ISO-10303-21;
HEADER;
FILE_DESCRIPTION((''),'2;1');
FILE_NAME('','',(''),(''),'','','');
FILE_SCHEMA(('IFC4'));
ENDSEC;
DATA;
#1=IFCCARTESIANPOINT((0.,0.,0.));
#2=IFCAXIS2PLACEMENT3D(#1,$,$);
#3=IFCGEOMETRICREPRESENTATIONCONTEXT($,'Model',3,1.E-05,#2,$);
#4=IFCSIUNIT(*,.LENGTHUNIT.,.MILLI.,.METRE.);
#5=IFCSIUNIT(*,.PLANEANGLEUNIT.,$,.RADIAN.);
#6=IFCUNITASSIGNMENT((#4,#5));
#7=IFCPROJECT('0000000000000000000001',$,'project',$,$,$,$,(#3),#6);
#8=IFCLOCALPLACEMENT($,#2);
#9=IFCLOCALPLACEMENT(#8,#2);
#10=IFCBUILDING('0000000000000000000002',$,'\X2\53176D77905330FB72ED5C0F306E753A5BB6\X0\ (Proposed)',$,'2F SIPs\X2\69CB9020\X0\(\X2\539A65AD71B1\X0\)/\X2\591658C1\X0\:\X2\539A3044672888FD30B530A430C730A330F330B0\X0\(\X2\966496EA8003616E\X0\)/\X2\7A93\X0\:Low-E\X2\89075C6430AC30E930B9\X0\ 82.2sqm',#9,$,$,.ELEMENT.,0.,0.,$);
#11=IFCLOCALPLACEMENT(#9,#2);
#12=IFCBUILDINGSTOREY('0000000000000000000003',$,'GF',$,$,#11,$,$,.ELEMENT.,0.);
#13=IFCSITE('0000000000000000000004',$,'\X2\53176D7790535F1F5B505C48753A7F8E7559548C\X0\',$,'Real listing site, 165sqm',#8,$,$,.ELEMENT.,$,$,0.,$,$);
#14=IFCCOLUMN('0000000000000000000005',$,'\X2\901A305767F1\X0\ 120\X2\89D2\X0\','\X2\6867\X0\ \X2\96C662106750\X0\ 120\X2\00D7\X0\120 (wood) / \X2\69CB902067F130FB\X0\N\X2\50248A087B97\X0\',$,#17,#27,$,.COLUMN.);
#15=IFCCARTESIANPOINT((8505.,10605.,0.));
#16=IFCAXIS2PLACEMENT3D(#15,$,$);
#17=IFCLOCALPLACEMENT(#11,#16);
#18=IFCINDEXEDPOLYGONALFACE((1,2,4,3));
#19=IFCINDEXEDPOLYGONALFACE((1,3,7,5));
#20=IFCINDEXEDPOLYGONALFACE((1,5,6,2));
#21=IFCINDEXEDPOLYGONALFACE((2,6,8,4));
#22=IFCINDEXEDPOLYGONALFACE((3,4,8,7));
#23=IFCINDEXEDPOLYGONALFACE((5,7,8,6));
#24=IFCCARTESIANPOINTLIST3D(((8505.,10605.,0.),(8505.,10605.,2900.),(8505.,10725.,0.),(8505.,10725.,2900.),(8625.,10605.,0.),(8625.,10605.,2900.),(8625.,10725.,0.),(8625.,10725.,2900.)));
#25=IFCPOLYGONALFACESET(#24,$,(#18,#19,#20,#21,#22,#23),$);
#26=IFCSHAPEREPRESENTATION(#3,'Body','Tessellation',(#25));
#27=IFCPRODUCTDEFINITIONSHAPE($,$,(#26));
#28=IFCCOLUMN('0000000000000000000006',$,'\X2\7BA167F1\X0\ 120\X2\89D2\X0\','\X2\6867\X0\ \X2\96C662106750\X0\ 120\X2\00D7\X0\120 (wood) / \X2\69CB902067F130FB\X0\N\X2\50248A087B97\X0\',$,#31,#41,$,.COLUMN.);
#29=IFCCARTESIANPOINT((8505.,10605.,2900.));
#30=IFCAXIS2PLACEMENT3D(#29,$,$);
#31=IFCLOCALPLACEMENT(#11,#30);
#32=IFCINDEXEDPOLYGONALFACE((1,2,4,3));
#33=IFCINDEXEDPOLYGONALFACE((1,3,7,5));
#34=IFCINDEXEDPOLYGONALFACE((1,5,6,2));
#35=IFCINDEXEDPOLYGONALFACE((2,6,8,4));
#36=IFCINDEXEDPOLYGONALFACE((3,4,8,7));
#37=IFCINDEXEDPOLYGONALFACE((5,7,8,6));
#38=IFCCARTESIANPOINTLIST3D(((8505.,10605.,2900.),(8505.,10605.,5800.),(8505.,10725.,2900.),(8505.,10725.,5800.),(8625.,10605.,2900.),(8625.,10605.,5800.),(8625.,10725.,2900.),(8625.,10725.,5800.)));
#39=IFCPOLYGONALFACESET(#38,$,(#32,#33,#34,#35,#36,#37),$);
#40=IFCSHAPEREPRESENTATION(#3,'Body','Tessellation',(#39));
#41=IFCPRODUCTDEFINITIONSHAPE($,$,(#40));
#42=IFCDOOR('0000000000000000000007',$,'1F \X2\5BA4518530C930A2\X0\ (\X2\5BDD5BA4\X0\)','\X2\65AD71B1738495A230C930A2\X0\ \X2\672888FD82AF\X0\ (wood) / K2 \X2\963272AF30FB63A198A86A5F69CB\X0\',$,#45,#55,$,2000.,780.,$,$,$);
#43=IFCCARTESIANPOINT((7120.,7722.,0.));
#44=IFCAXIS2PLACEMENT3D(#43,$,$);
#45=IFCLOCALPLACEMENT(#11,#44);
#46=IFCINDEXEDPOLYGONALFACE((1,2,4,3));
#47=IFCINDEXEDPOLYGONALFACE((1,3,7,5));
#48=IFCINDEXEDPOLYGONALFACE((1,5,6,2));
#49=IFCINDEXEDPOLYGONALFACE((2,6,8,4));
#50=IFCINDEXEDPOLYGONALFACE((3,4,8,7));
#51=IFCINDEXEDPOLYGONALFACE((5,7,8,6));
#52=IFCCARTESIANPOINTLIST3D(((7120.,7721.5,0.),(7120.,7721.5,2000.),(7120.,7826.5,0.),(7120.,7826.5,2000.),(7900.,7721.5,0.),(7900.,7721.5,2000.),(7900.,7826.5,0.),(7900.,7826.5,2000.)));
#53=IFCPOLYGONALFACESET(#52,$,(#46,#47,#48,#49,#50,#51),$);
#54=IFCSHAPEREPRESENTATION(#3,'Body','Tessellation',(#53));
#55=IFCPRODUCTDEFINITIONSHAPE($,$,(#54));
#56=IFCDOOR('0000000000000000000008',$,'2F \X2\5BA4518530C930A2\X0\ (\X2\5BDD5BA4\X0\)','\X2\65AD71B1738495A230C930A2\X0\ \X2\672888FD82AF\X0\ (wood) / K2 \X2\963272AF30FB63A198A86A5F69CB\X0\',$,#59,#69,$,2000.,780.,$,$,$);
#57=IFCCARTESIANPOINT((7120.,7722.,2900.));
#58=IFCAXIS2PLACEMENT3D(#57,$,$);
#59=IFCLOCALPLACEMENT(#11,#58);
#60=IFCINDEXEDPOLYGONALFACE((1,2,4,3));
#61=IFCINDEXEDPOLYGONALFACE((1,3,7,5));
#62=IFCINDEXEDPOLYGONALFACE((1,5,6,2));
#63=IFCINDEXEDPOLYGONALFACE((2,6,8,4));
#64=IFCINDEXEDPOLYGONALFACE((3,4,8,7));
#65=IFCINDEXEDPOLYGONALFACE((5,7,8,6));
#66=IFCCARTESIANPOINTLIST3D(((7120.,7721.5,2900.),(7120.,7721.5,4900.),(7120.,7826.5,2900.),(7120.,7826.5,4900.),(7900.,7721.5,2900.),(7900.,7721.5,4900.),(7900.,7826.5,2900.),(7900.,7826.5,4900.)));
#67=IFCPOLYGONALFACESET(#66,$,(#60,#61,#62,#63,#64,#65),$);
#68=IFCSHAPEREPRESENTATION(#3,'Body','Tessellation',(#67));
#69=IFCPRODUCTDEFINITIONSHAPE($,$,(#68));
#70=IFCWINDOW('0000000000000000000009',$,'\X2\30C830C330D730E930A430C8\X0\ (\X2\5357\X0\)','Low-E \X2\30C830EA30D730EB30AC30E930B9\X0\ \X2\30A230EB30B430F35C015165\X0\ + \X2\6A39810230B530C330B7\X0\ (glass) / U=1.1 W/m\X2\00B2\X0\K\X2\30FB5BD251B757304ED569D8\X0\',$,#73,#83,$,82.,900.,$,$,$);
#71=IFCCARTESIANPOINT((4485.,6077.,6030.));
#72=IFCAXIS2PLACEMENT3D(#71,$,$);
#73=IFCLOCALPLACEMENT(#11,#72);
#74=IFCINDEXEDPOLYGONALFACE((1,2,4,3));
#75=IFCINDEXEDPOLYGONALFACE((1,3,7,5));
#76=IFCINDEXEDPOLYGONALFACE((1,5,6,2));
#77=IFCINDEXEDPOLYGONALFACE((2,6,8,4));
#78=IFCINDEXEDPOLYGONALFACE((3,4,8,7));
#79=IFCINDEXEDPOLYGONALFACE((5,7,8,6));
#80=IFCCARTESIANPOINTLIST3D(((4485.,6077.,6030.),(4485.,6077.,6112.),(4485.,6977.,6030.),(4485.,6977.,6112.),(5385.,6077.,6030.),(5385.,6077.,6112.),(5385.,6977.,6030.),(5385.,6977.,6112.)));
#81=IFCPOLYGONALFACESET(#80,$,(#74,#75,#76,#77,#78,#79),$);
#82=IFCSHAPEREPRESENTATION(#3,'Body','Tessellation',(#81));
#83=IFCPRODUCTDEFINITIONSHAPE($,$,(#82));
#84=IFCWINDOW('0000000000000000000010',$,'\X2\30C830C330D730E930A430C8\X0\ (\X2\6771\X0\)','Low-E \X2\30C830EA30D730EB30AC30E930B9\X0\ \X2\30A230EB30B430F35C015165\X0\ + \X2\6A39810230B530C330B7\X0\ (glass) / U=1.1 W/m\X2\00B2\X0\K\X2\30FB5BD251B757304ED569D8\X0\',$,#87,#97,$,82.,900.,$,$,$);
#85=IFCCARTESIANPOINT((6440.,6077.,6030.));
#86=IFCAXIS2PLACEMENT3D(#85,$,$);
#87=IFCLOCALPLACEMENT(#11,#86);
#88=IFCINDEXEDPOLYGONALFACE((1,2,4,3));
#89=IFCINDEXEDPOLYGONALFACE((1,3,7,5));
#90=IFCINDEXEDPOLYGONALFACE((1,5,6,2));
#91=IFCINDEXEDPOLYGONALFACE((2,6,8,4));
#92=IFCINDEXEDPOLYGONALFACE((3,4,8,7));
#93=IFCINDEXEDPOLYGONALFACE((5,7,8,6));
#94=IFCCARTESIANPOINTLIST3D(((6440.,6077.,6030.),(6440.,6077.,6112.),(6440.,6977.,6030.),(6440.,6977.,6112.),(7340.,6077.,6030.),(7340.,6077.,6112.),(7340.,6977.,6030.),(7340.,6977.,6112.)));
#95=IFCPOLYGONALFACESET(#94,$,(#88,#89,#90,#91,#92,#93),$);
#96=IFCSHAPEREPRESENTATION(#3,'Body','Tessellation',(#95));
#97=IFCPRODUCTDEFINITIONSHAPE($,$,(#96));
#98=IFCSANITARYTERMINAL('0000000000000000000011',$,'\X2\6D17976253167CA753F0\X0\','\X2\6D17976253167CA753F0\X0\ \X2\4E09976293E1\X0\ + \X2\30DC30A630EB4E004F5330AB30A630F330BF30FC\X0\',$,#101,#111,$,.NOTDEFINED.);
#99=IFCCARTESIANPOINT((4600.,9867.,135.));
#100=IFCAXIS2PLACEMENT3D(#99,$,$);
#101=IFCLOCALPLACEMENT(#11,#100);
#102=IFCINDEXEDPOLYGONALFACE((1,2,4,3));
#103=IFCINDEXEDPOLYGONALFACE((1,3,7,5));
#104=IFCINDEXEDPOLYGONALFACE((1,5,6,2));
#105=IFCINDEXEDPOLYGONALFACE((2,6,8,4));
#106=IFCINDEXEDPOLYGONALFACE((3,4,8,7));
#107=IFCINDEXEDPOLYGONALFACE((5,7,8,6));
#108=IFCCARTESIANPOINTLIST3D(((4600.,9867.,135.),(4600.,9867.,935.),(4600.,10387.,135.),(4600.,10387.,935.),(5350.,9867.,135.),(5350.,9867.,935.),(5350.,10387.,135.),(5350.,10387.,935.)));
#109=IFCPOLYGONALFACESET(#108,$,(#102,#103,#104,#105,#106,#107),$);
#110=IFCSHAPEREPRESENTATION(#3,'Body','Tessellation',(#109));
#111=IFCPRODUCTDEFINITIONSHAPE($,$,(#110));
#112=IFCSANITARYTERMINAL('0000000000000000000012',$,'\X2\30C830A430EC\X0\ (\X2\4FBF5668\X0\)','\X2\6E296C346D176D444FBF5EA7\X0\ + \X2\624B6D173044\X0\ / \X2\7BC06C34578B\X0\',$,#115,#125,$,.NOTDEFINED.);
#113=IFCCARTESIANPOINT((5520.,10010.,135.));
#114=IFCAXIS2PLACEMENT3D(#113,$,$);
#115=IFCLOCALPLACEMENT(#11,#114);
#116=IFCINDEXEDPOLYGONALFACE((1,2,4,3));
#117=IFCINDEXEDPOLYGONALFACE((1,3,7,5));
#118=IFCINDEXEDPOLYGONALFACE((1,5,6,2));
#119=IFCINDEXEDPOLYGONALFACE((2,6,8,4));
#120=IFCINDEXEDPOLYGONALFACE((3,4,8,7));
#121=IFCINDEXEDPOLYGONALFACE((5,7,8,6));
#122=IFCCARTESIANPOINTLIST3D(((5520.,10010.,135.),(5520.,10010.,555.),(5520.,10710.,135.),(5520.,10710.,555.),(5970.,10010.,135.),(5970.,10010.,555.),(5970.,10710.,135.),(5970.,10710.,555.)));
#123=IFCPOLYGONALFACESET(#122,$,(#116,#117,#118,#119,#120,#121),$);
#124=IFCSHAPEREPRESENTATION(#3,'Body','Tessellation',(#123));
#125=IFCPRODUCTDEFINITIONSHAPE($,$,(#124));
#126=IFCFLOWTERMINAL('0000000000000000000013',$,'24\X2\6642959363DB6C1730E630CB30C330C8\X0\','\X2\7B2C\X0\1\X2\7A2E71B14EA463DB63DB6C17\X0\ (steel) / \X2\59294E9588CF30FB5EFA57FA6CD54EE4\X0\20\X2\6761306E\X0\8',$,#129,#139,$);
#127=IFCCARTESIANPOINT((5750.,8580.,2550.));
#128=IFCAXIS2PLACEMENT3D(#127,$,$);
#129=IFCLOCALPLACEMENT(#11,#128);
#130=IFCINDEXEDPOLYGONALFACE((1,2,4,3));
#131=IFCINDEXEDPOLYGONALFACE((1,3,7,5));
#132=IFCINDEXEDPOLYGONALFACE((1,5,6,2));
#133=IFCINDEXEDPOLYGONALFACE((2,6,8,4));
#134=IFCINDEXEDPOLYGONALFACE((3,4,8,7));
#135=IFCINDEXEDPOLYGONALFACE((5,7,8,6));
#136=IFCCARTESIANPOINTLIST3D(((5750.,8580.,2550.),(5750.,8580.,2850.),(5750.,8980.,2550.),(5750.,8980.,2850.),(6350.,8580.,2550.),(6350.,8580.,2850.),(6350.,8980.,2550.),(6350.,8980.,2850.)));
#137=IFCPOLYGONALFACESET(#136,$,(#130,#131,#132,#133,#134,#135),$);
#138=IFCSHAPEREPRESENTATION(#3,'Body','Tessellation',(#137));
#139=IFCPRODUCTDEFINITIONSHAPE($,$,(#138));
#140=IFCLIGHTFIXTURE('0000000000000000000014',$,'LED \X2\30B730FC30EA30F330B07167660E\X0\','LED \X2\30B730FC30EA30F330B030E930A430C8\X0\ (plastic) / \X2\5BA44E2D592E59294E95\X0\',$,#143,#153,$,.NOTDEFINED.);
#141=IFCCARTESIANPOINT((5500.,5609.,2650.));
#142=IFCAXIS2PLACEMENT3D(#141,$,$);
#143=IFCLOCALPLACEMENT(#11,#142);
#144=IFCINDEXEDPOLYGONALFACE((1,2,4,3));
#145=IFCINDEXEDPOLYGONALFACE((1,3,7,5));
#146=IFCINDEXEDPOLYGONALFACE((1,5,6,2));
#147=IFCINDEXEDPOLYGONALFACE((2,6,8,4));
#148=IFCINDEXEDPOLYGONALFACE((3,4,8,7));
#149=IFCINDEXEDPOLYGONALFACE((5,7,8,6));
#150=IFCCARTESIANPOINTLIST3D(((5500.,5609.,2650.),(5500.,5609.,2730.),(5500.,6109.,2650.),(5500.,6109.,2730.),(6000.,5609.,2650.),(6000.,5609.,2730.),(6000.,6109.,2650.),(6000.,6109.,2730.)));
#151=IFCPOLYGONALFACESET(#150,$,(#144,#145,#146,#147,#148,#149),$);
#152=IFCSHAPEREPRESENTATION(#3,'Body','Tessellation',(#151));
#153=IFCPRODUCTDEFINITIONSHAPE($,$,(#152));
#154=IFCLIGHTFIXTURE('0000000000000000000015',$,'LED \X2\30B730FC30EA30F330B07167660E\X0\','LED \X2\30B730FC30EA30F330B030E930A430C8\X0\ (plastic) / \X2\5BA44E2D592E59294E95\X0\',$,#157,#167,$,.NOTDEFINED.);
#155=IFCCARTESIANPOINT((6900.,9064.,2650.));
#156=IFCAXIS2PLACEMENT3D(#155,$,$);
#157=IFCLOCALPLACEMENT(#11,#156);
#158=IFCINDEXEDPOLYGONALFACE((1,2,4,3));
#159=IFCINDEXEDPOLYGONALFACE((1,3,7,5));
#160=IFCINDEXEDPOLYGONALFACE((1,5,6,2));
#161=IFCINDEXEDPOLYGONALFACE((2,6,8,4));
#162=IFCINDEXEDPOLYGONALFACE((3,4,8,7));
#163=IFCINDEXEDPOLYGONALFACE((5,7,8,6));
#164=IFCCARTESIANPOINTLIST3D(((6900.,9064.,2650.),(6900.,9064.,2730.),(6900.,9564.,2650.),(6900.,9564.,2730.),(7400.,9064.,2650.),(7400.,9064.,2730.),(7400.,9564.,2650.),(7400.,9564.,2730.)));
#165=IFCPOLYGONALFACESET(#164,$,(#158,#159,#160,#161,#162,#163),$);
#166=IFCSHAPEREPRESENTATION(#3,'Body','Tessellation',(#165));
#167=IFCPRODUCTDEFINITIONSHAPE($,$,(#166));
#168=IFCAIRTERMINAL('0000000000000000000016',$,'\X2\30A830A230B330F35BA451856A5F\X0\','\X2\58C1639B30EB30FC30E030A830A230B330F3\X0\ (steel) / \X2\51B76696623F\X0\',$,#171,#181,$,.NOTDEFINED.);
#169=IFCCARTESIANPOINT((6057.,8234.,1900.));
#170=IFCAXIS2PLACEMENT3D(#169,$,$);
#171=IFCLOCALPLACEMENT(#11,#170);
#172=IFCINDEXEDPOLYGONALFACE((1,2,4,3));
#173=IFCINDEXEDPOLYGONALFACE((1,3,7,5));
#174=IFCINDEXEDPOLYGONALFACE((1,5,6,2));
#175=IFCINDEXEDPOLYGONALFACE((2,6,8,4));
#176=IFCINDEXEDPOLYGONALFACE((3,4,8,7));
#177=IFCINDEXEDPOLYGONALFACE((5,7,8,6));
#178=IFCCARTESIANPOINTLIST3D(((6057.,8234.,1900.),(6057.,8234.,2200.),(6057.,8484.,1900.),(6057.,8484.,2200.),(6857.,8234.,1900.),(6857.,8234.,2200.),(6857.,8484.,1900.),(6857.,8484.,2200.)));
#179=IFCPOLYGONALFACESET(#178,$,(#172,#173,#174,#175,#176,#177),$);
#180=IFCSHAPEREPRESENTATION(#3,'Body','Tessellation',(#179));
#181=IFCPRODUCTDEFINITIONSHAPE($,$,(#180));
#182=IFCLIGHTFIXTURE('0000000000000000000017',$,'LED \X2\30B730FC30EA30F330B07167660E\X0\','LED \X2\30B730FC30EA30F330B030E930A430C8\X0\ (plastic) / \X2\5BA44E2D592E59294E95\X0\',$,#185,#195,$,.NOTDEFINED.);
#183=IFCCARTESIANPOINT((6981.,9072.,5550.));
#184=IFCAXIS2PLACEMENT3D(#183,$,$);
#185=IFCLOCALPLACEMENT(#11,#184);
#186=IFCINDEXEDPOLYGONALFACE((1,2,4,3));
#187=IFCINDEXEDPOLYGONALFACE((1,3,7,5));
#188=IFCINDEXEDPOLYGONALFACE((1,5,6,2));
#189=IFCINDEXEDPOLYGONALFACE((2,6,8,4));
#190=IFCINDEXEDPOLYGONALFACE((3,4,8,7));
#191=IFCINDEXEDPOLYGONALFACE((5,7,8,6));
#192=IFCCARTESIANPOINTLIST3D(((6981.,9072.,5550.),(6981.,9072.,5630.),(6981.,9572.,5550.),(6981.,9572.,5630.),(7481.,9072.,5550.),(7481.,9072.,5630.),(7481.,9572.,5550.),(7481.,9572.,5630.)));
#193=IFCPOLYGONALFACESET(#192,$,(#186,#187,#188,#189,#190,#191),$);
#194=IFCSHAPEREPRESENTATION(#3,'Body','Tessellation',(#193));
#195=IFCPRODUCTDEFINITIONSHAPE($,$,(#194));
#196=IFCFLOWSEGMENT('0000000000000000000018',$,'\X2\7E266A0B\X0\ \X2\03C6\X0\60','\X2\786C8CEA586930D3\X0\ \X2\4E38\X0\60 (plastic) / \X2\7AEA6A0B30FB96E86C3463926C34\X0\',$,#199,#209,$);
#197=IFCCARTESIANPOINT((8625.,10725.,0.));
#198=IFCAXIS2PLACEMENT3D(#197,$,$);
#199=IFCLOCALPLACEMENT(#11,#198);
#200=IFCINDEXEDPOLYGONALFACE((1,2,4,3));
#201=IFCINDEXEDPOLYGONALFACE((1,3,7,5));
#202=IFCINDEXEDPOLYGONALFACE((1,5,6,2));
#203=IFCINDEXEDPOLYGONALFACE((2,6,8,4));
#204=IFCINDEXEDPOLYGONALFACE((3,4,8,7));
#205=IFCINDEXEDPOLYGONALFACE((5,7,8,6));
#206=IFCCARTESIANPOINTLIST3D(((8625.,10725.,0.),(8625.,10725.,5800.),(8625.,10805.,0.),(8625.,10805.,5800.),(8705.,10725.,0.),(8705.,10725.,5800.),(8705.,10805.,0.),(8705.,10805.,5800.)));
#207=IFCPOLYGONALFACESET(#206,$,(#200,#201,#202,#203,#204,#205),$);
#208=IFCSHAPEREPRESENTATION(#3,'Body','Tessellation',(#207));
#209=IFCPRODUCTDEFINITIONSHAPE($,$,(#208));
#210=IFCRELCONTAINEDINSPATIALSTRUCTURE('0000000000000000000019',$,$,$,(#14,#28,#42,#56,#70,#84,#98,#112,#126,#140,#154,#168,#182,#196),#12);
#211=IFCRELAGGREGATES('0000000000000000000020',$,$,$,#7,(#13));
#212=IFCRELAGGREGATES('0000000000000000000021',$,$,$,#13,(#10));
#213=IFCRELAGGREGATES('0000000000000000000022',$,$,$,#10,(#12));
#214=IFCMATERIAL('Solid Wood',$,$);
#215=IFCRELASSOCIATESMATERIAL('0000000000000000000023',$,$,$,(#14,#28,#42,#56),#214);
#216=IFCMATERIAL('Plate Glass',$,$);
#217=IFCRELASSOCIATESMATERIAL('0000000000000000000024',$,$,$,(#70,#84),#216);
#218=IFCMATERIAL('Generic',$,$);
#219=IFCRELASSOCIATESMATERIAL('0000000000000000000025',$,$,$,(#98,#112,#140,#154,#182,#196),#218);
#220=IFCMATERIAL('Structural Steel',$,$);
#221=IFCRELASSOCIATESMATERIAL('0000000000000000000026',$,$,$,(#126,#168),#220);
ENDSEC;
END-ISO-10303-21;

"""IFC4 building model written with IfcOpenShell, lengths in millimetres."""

from ifc_helpers import new_model, si_unit, frame, frame_2d, origin, place, context, project, spatial, rectangle, extrude, material, element, save


model = new_model("IFC4")

# Units and contexts
model_context = context("Model", 3, precision=1e-05, world=origin())
ifc_project = project(units=[si_unit("LENGTHUNIT", "METRE", prefix="MILLI"), si_unit("PLANEANGLEUNIT", "RADIAN")], contexts=[model_context])

# Site, building, storey
site_placement = place(None, origin())
site = spatial("IfcSite", under=ifc_project, at=site_placement, Name="北海道弟子屈町美留和", ObjectType="Real listing site, 165sqm", CompositionType="ELEMENT", RefElevation=0.0)
building_placement = place(site_placement, origin())
building = spatial("IfcBuilding", under=site, at=building_placement, Name="北海道・狭小の町家 (Proposed)", ObjectType="2F SIPs構造(厚断熱)/外壁:厚い木製サイディング(除雪考慮)/窓:Low-E複層ガラス 82.2sqm", CompositionType="ELEMENT", ElevationOfRefHeight=0.0, ElevationOfTerrain=0.0)
storey_placement = place(building_placement, origin())
storey = spatial("IfcBuildingStorey", under=building, at=storey_placement, Name="GF", CompositionType="ELEMENT", Elevation=0.0)

# Columns
ifc_material_1 = material(Name="Solid Wood")
column_1_placement = place(storey_placement, frame((8505.0, 10605.0, 0.0)))
element("IfcColumn", 1, at=column_1_placement, inside=storey, material=ifc_material_1, Name="通し柱 120角", Description="桧 集成材 120×120 (wood) / 構造柱・N値計算", PredefinedType="COLUMN", context=model_context, shape_type="SweptSolid", body=[
    extrude(rectangle(XDim=120.0, YDim=120.0, at=frame_2d((60.0, 60.0))), frame((8505.0, 10605.0, 0.0)), (0.0, 0.0, 1.0), 2900.0),
])
column_2_placement = place(storey_placement, frame((8505.0, 10605.0, 2900.0)))
element("IfcColumn", 2, at=column_2_placement, inside=storey, material=ifc_material_1, Name="管柱 120角", Description="桧 集成材 120×120 (wood) / 構造柱・N値計算", PredefinedType="COLUMN", context=model_context, shape_type="SweptSolid", body=[
    extrude(rectangle(XDim=120.0, YDim=120.0, at=frame_2d((60.0, 60.0))), frame((8505.0, 10605.0, 2900.0)), (0.0, 0.0, 1.0), 2900.0),
])

# Door
door_1_placement = place(storey_placement, frame((7120.0, 7722.0, 0.0)))
element("IfcDoor", 3, at=door_1_placement, inside=storey, material=ifc_material_1, Name="1F 室内ドア (寝室)", Description="断熱玄関ドア 木製芯 (wood) / K2 防犯・採風機構", OverallHeight=2000.0, OverallWidth=780.0, context=model_context, shape_type="SweptSolid", body=[
    extrude(rectangle(XDim=780.0, YDim=105.0, at=frame_2d((390.0, 52.0))), frame((7120.0, 7722.0, 0.0)), (0.0, 0.0, 1.0), 2000.0),
])

# Door
door_2_placement = place(storey_placement, frame((7120.0, 7722.0, 2900.0)))
element("IfcDoor", 4, at=door_2_placement, inside=storey, material=ifc_material_1, Name="2F 室内ドア (寝室)", Description="断熱玄関ドア 木製芯 (wood) / K2 防犯・採風機構", OverallHeight=2000.0, OverallWidth=780.0, context=model_context, shape_type="SweptSolid", body=[
    extrude(rectangle(XDim=780.0, YDim=105.0, at=frame_2d((390.0, 52.0))), frame((7120.0, 7722.0, 2900.0)), (0.0, 0.0, 1.0), 2000.0),
])

# Windows
ifc_material_2 = material(Name="Plate Glass")
window_1_placement = place(storey_placement, frame((4485.0, 6077.0, 6030.0)))
element("IfcWindow", 5, at=window_1_placement, inside=storey, material=ifc_material_2, Name="トップライト (南)", Description="Low-E トリプルガラス アルゴン封入 + 樹脂サッシ (glass) / U=1.1 W/m²K・寒冷地仕様", OverallHeight=82.0, OverallWidth=900.0, context=model_context, shape_type="SweptSolid", body=[
    extrude(rectangle(XDim=900.0, YDim=900.0, at=frame_2d((450.0, 450.0))), frame((4485.0, 6077.0, 6030.0)), (0.0, 0.0, 1.0), 82.0),
])
window_2_placement = place(storey_placement, frame((6440.0, 6077.0, 6030.0)))
element("IfcWindow", 6, at=window_2_placement, inside=storey, material=ifc_material_2, Name="トップライト (東)", Description="Low-E トリプルガラス アルゴン封入 + 樹脂サッシ (glass) / U=1.1 W/m²K・寒冷地仕様", OverallHeight=82.0, OverallWidth=900.0, context=model_context, shape_type="SweptSolid", body=[
    extrude(rectangle(XDim=900.0, YDim=900.0, at=frame_2d((450.0, 450.0))), frame((6440.0, 6077.0, 6030.0)), (0.0, 0.0, 1.0), 82.0),
])

# Sanitary terminals
ifc_material_3 = material(Name="Generic")
sanitary_terminal_1_placement = place(storey_placement, frame((4600.0, 9867.0, 135.0)))
element("IfcSanitaryTerminal", 7, at=sanitary_terminal_1_placement, inside=storey, material=ifc_material_3, Name="洗面化粧台", Description="洗面化粧台 三面鏡 + ボウル一体カウンター", PredefinedType="NOTDEFINED", context=model_context, shape_type="SweptSolid", body=[
    extrude(rectangle(XDim=750.0, YDim=520.0, at=frame_2d((375.0, 260.0))), frame((4600.0, 9867.0, 135.0)), (0.0, 0.0, 1.0), 800.0),
])
sanitary_terminal_2_placement = place(storey_placement, frame((5520.0, 10010.0, 135.0)))
element("IfcSanitaryTerminal", 8, at=sanitary_terminal_2_placement, inside=storey, material=ifc_material_3, Name="トイレ (便器)", Description="温水洗浄便座 + 手洗い / 節水型", PredefinedType="NOTDEFINED", context=model_context, shape_type="SweptSolid", body=[
    extrude(rectangle(XDim=450.0, YDim=700.0, at=frame_2d((225.0, 350.0))), frame((5520.0, 10010.0, 135.0)), (0.0, 0.0, 1.0), 420.0),
])

# Flow terminal
ifc_material_4 = material(Name="Structural Steel")
flow_terminal_placement = place(storey_placement, frame((5750.0, 8580.0, 2550.0)))
element("IfcFlowTerminal", 9, at=flow_terminal_placement, inside=storey, material=ifc_material_4, Name="24時間換気ユニット", Description="第1種熱交換換気 (steel) / 天井裏・建基法令20条の8", context=model_context, shape_type="SweptSolid", body=[
    extrude(rectangle(XDim=600.0, YDim=400.0, at=frame_2d((300.0, 200.0))), frame((5750.0, 8580.0, 2550.0)), (0.0, 0.0, 1.0), 300.0),
])

# Light fixtures
light_fixture_1_placement = place(storey_placement, frame((5500.0, 5609.0, 2650.0)))
element("IfcLightFixture", 10, at=light_fixture_1_placement, inside=storey, material=ifc_material_3, Name="LED シーリング照明", Description="LED シーリングライト (plastic) / 室中央天井", PredefinedType="NOTDEFINED", context=model_context, shape_type="SweptSolid", body=[
    extrude(rectangle(XDim=500.0, YDim=500.0, at=frame_2d((250.0, 250.0))), frame((5500.0, 5609.0, 2650.0)), (0.0, 0.0, 1.0), 80.0),
])
light_fixture_2_placement = place(storey_placement, frame((6900.0, 9064.0, 2650.0)))
element("IfcLightFixture", 11, at=light_fixture_2_placement, inside=storey, material=ifc_material_3, Name="LED シーリング照明", Description="LED シーリングライト (plastic) / 室中央天井", PredefinedType="NOTDEFINED", context=model_context, shape_type="SweptSolid", body=[
    extrude(rectangle(XDim=500.0, YDim=500.0, at=frame_2d((250.0, 250.0))), frame((6900.0, 9064.0, 2650.0)), (0.0, 0.0, 1.0), 80.0),
])

# Air terminal
air_terminal_placement = place(storey_placement, frame((6057.0, 8234.0, 1900.0)))
element("IfcAirTerminal", 12, at=air_terminal_placement, inside=storey, material=ifc_material_4, Name="エアコン室内機", Description="壁掛ルームエアコン (steel) / 冷暖房", PredefinedType="NOTDEFINED", context=model_context, shape_type="SweptSolid", body=[
    extrude(rectangle(XDim=800.0, YDim=250.0, at=frame_2d((400.0, 125.0))), frame((6057.0, 8234.0, 1900.0)), (0.0, 0.0, 1.0), 300.0),
])

# Light fixture
light_fixture_3_placement = place(storey_placement, frame((6981.0, 9072.0, 5550.0)))
element("IfcLightFixture", 13, at=light_fixture_3_placement, inside=storey, material=ifc_material_3, Name="LED シーリング照明", Description="LED シーリングライト (plastic) / 室中央天井", PredefinedType="NOTDEFINED", context=model_context, shape_type="SweptSolid", body=[
    extrude(rectangle(XDim=500.0, YDim=500.0, at=frame_2d((250.0, 250.0))), frame((6981.0, 9072.0, 5550.0)), (0.0, 0.0, 1.0), 80.0),
])

# Flow segment
flow_segment_placement = place(storey_placement, frame((8625.0, 10725.0, 0.0)))
element("IfcFlowSegment", 14, at=flow_segment_placement, inside=storey, material=ifc_material_3, Name="縦樋 φ60", Description="硬質塩ビ 丸60 (plastic) / 竪樋・雨水排水", context=model_context, shape_type="SweptSolid", body=[
    extrude(rectangle(XDim=80.0, YDim=80.0, at=frame_2d((40.0, 40.0))), frame((8625.0, 10725.0, 0.0)), (0.0, 0.0, 1.0), 5800.0),
])

save(model, "model.ifc")
